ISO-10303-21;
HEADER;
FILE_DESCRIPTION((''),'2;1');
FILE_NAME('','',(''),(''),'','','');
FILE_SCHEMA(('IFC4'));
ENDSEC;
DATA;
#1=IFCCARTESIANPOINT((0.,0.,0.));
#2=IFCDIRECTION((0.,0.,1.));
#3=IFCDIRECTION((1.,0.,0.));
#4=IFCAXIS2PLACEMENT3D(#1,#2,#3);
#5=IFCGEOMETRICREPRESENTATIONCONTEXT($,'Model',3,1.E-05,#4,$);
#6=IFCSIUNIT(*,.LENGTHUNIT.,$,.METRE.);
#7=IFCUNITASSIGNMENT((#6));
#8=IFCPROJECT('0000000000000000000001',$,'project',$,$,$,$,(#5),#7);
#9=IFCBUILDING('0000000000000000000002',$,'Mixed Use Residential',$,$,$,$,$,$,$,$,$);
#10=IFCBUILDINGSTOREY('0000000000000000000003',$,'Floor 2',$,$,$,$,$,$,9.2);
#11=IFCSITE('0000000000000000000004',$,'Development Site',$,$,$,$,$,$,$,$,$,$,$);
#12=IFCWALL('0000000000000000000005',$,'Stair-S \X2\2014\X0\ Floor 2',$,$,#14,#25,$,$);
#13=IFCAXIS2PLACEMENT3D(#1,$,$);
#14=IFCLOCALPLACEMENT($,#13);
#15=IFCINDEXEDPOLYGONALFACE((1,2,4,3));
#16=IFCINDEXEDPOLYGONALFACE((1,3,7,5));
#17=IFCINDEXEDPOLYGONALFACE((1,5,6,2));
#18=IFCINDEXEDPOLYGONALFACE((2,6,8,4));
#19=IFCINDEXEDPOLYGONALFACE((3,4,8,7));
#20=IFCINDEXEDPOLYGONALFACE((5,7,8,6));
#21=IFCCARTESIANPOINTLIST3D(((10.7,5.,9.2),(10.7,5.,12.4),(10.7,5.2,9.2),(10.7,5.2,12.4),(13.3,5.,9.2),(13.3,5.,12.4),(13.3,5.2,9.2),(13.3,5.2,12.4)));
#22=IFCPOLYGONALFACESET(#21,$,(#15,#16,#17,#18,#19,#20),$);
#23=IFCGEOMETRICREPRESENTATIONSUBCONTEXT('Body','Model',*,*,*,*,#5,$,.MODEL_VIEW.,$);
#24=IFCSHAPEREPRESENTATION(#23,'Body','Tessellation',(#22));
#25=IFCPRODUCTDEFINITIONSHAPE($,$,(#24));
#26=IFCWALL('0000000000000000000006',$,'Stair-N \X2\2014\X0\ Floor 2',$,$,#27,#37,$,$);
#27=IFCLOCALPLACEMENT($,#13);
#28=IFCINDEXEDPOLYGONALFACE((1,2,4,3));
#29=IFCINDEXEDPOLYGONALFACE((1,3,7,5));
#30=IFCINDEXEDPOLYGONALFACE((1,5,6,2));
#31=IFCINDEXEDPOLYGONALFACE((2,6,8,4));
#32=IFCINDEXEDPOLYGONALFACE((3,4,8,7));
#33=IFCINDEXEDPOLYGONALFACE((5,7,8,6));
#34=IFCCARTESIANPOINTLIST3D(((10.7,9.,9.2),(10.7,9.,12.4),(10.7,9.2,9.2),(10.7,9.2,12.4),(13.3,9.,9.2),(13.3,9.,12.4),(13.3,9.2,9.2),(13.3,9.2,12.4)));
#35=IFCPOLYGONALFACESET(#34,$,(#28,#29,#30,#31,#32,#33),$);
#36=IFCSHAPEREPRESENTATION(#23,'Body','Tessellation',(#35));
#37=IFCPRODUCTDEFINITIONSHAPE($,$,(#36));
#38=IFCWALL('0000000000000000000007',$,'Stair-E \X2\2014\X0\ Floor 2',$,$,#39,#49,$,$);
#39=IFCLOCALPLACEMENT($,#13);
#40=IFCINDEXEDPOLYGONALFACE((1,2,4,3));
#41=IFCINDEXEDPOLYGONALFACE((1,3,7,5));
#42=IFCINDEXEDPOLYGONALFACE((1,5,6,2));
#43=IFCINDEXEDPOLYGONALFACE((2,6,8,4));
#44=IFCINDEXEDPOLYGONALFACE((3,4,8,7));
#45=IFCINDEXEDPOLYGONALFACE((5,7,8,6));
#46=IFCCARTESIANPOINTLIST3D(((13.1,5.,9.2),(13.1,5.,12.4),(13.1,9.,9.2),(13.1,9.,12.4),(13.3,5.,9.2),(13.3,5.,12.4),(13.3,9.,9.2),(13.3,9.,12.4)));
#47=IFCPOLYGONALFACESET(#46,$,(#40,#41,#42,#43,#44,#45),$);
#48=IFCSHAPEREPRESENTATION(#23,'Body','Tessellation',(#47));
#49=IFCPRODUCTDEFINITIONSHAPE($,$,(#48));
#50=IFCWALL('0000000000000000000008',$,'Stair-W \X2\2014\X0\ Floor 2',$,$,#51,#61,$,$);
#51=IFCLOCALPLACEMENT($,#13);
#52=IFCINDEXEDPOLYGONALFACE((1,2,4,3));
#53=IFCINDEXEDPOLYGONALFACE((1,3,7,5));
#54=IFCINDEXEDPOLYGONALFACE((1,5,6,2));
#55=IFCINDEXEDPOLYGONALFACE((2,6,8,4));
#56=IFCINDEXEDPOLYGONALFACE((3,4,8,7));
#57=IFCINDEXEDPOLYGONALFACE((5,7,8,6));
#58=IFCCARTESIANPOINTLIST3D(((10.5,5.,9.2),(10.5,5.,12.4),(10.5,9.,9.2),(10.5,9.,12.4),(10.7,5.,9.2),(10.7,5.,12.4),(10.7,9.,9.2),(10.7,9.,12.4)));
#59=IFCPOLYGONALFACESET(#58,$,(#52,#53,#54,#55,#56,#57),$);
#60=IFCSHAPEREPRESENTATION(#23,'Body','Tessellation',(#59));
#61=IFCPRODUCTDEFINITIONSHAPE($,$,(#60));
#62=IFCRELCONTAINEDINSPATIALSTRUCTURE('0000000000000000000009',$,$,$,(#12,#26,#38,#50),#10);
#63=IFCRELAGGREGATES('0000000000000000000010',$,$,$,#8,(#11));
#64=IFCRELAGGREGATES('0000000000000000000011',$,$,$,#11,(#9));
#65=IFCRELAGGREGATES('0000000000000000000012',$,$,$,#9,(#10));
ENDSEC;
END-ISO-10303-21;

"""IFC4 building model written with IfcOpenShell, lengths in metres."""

from ifc_helpers import new_model, si_unit, frame, origin_with_axes, place, context, subcontext, project, spatial, indexed_curve, outline, extrude, element, save


model = new_model("IFC4")

# Units and contexts
model_context = context("Model", 3, precision=1e-05, world=origin_with_axes())
body_context = subcontext(model_context, "Body", "Model", "MODEL_VIEW")
ifc_project = project(units=[si_unit("LENGTHUNIT", "METRE")], contexts=[model_context])

# Site, building, storey
site = spatial("IfcSite", under=ifc_project, Name="Development Site")
building = spatial("IfcBuilding", under=site, Name="Mixed Use Residential")
storey = spatial("IfcBuildingStorey", under=building, Name="Floor 2", Elevation=9.2)

# Walls
for number, where, z_axis, x_axis, name in (
    (1, (10.7, 5.0, 9.2), (0.0, 0.0, 1.0), (1.0, 0.0, 0.0), "Stair-S — Floor 2"),
    (2, (10.7, 9.0, 9.2), (0.0, 0.0, 1.0), (1.0, 0.0, 0.0), "Stair-N — Floor 2"),
):
    element("IfcWall", number, at=place(None, frame(where, z_axis=z_axis, x_axis=x_axis)), inside=storey, Name=name, context=body_context, shape_type="SweptSolid", body=[
        extrude(outline(indexed_curve([(0.0, 0.0), (0.0, 0.2), (2.6, 0.2), (2.6, 0.0), (0.0, 0.0)], self_intersect=False)), origin_with_axes(), (0.0, 0.0, 1.0), 3.2),
    ])
for number, where, z_axis, x_axis, name in (
    (3, (13.3, 5.0, 9.2), (0.0, 0.0, 1.0), (0.0, 1.0, 0.0), "Stair-E — Floor 2"),
    (4, (10.7, 5.0, 9.2), (0.0, 0.0, 1.0), (0.0, 1.0, 0.0), "Stair-W — Floor 2"),
):
    element("IfcWall", number, at=place(None, frame(where, z_axis=z_axis, x_axis=x_axis)), inside=storey, Name=name, context=body_context, shape_type="SweptSolid", body=[
        extrude(outline(indexed_curve([(0.0, 0.0), (0.0, 0.2), (4.0, 0.2), (4.0, 0.0), (0.0, 0.0)], self_intersect=False)), origin_with_axes(), (0.0, 0.0, 1.0), 3.2),
    ])

save(model, "model.ifc")
